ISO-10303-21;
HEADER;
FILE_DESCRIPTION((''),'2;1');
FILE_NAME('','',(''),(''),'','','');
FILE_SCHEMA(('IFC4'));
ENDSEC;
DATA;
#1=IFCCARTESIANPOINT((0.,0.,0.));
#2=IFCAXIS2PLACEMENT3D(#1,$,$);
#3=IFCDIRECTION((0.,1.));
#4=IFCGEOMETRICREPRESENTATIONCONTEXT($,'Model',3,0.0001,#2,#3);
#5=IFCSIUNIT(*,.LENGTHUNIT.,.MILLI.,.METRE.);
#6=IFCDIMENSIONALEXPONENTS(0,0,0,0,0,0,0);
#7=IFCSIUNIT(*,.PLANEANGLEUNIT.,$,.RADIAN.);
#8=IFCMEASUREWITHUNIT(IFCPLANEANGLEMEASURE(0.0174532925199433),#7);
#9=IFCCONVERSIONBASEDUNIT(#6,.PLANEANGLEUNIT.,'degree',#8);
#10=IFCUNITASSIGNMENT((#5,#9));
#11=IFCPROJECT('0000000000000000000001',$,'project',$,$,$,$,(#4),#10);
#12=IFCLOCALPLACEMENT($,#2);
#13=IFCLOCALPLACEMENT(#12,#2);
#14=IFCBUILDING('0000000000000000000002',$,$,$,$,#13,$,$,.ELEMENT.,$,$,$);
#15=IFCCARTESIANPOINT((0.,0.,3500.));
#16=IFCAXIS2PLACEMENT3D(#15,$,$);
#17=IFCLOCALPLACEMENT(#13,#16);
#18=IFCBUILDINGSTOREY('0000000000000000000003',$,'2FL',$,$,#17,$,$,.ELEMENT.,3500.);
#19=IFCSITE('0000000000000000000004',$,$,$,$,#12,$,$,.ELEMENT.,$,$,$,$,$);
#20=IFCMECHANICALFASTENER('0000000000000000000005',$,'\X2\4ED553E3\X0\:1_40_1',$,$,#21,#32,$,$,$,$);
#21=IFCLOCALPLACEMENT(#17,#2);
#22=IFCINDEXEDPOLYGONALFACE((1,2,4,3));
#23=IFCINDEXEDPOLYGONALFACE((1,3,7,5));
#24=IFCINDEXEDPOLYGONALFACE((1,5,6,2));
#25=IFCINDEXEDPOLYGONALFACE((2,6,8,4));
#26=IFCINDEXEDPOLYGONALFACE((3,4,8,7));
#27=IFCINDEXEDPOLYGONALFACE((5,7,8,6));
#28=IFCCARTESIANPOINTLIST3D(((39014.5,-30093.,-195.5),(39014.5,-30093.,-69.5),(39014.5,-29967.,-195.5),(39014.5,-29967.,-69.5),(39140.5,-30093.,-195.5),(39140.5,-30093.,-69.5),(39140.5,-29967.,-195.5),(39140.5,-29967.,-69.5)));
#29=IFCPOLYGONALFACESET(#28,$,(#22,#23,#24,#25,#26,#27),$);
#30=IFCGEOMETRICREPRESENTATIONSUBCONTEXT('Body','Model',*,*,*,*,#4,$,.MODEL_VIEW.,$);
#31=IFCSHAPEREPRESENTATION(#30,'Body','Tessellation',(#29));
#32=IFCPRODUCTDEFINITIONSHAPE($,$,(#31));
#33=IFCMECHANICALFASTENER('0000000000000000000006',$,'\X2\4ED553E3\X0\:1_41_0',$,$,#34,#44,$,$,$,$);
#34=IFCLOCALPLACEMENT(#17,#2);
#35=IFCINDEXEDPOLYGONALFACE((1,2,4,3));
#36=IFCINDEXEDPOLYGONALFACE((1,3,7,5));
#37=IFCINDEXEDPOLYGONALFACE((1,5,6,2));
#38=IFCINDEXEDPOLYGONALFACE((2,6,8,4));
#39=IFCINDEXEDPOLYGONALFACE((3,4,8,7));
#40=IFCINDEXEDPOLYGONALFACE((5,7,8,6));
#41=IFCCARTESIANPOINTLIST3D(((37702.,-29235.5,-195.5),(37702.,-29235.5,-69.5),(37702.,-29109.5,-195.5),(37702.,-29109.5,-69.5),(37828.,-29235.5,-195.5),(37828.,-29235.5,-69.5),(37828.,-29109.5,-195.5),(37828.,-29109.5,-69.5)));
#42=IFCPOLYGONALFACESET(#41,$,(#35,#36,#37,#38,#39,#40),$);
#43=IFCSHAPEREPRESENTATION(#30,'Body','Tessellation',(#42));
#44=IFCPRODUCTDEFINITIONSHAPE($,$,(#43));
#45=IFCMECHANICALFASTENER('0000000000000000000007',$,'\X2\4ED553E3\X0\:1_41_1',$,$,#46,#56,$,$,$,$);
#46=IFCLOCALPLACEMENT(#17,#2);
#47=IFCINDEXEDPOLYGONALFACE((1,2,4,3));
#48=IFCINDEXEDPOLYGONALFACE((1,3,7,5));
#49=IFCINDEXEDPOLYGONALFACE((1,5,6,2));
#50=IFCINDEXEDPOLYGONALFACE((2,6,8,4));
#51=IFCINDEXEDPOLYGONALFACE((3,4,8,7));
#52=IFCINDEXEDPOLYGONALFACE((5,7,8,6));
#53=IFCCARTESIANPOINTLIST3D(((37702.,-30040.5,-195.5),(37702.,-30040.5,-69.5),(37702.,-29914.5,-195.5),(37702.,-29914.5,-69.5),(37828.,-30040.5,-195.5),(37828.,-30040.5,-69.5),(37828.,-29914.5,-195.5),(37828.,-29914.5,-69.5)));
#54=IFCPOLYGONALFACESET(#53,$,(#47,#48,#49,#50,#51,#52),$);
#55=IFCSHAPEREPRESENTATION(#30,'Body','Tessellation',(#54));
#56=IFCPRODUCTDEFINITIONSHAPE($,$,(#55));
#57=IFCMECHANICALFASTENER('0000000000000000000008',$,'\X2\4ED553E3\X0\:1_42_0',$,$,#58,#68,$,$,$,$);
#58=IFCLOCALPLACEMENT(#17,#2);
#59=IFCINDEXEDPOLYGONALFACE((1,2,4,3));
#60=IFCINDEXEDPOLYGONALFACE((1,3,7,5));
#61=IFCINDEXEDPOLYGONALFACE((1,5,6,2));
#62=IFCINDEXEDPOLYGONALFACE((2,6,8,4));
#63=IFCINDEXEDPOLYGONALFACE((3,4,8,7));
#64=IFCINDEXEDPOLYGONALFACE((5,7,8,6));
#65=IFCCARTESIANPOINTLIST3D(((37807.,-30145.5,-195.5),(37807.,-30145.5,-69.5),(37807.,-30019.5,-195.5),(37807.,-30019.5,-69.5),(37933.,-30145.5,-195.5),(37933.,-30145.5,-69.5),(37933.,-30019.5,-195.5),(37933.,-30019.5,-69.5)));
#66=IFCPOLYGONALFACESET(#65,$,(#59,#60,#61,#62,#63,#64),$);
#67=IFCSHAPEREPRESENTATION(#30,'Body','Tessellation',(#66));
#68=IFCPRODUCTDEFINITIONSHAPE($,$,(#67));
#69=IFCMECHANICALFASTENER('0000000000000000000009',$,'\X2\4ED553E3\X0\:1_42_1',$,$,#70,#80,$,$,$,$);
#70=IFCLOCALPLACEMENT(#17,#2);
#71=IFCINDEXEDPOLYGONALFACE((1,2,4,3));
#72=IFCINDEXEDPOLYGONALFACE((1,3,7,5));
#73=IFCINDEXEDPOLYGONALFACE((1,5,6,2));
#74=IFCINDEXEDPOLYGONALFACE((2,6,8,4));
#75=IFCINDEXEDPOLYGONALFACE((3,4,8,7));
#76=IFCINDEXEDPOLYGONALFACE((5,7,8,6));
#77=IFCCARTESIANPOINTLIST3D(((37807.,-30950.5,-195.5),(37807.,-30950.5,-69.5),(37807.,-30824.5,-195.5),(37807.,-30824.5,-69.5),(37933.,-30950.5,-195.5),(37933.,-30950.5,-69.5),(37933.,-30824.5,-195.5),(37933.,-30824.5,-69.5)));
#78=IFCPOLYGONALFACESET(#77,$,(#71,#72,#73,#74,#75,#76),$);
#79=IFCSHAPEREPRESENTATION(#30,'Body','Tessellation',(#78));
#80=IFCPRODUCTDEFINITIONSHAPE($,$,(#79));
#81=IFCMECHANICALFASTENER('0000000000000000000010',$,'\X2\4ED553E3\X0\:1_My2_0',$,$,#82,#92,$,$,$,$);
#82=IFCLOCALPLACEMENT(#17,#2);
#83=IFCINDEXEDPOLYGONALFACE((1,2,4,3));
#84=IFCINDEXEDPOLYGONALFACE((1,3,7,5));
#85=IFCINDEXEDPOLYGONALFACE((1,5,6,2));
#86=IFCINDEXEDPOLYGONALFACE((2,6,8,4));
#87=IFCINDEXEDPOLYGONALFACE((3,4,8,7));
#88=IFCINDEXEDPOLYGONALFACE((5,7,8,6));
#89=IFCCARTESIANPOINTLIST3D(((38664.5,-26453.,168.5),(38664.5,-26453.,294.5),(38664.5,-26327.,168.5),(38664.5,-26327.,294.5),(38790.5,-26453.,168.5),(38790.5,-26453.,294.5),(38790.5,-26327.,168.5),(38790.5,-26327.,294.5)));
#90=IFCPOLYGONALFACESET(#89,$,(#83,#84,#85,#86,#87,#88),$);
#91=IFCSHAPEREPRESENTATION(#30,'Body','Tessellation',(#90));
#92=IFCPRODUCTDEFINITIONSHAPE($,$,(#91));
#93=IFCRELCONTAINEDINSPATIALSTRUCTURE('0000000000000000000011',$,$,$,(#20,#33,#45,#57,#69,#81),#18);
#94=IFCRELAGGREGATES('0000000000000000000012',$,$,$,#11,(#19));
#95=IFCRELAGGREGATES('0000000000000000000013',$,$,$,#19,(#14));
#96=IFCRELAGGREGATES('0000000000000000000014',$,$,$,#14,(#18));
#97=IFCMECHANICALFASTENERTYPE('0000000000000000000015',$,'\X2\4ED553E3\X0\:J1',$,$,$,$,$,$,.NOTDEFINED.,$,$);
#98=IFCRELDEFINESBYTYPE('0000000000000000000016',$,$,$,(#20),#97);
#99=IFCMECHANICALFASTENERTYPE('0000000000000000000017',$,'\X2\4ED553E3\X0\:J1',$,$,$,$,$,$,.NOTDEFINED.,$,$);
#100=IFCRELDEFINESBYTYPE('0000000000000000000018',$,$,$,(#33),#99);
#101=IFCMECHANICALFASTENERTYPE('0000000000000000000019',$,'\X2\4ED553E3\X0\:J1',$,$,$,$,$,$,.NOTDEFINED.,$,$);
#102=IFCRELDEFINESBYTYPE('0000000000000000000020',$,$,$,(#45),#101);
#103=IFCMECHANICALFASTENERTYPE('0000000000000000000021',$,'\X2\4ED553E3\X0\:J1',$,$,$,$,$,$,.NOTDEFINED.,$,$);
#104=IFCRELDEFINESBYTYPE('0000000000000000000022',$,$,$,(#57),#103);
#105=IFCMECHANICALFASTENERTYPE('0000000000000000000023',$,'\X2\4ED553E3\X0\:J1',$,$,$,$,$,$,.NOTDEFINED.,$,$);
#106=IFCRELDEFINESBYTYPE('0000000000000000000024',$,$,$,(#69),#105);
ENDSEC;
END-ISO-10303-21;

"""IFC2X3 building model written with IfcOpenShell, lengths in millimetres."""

from ifc_helpers import new_model, entity, si_unit, converted_unit, direction, frame, origin, origin_with_axes, origin_2d, place, context, subcontext, project, spatial, rectangle, extrude, type_object, element, save


model = new_model("IFC2X3")

# Units and contexts
model_context = context("Model", 3, precision=0.0001, world=origin(), true_north=direction((0.0, 1.0)))
body_context = subcontext(model_context, "Body", "Model", "MODEL_VIEW")
ifc_project = project(units=[si_unit("LENGTHUNIT", "METRE", prefix="MILLI"), converted_unit("PLANEANGLEUNIT", "degree", entity("IfcPlaneAngleMeasure", 0.0174532925199433), si_unit("PLANEANGLEUNIT", "RADIAN"), dimensions=[0, 0, 0, 0, 0, 0, 0])], contexts=[model_context])

# Site, building, storey
site_placement = place(None, origin())
site = spatial("IfcSite", under=ifc_project, at=site_placement, CompositionType="ELEMENT")
building_placement = place(site_placement, origin())
building = spatial("IfcBuilding", under=site, at=building_placement, CompositionType="ELEMENT")
storey_placement = place(building_placement, frame((0.0, 0.0, 3500.0)))
storey = spatial("IfcBuildingStorey", under=building, at=storey_placement, Name="2FL", CompositionType="ELEMENT", Elevation=3500.0)

# Mechanical fasteners
mechanical_fastener_type_1 = type_object("IfcMechanicalFastenerType", Name="仕口:J1")
mechanical_fastener_1_placement = place(storey_placement, frame((39077.5, -30030.0, -195.5)))
element("IfcMechanicalFastener", 1, at=mechanical_fastener_1_placement, inside=storey, type_object=mechanical_fastener_type_1, Name="仕口:1_40_1", context=body_context, shape_type="SweptSolid", body=[
    extrude(rectangle(XDim=126.0, YDim=126.0, at=origin_2d()), origin_with_axes(), (0.0, 0.0, 1.0), 126.0),
])
mechanical_fastener_type_2 = type_object("IfcMechanicalFastenerType", Name="仕口:J1")
mechanical_fastener_2_placement = place(storey_placement, frame((37765.0, -29172.5, -195.5)))
element("IfcMechanicalFastener", 2, at=mechanical_fastener_2_placement, inside=storey, type_object=mechanical_fastener_type_2, Name="仕口:1_41_0", context=body_context, shape_type="SweptSolid", body=[
    extrude(rectangle(XDim=126.0, YDim=126.0, at=origin_2d()), origin_with_axes(), (0.0, 0.0, 1.0), 126.0),
])
mechanical_fastener_type_3 = type_object("IfcMechanicalFastenerType", Name="仕口:J1")
mechanical_fastener_3_placement = place(storey_placement, frame((37765.0, -29977.5, -195.5)))
element("IfcMechanicalFastener", 3, at=mechanical_fastener_3_placement, inside=storey, type_object=mechanical_fastener_type_3, Name="仕口:1_41_1", context=body_context, shape_type="SweptSolid", body=[
    extrude(rectangle(XDim=126.0, YDim=126.0, at=origin_2d()), origin_with_axes(), (0.0, 0.0, 1.0), 126.0),
])
mechanical_fastener_type_4 = type_object("IfcMechanicalFastenerType", Name="仕口:J1")
mechanical_fastener_4_placement = place(storey_placement, frame((37870.0, -30082.5, -195.5)))
element("IfcMechanicalFastener", 4, at=mechanical_fastener_4_placement, inside=storey, type_object=mechanical_fastener_type_4, Name="仕口:1_42_0", context=body_context, shape_type="SweptSolid", body=[
    extrude(rectangle(XDim=126.0, YDim=126.0, at=origin_2d()), origin_with_axes(), (0.0, 0.0, 1.0), 126.0),
])
mechanical_fastener_type_5 = type_object("IfcMechanicalFastenerType", Name="仕口:J1")
mechanical_fastener_5_placement = place(storey_placement, frame((37870.0, -30887.5, -195.5)))
element("IfcMechanicalFastener", 5, at=mechanical_fastener_5_placement, inside=storey, type_object=mechanical_fastener_type_5, Name="仕口:1_42_1", context=body_context, shape_type="SweptSolid", body=[
    extrude(rectangle(XDim=126.0, YDim=126.0, at=origin_2d()), origin_with_axes(), (0.0, 0.0, 1.0), 126.0),
])
mechanical_fastener_6_placement = place(storey_placement, frame((38727.5, -26390.0, 168.5)))
element("IfcMechanicalFastener", 6, at=mechanical_fastener_6_placement, inside=storey, Name="仕口:1_My2_0", context=body_context, shape_type="SweptSolid", body=[
    extrude(rectangle(XDim=126.0, YDim=126.0, at=origin_2d()), origin_with_axes(), (0.0, 0.0, 1.0), 126.0),
])

save(model, "model.ifc")
